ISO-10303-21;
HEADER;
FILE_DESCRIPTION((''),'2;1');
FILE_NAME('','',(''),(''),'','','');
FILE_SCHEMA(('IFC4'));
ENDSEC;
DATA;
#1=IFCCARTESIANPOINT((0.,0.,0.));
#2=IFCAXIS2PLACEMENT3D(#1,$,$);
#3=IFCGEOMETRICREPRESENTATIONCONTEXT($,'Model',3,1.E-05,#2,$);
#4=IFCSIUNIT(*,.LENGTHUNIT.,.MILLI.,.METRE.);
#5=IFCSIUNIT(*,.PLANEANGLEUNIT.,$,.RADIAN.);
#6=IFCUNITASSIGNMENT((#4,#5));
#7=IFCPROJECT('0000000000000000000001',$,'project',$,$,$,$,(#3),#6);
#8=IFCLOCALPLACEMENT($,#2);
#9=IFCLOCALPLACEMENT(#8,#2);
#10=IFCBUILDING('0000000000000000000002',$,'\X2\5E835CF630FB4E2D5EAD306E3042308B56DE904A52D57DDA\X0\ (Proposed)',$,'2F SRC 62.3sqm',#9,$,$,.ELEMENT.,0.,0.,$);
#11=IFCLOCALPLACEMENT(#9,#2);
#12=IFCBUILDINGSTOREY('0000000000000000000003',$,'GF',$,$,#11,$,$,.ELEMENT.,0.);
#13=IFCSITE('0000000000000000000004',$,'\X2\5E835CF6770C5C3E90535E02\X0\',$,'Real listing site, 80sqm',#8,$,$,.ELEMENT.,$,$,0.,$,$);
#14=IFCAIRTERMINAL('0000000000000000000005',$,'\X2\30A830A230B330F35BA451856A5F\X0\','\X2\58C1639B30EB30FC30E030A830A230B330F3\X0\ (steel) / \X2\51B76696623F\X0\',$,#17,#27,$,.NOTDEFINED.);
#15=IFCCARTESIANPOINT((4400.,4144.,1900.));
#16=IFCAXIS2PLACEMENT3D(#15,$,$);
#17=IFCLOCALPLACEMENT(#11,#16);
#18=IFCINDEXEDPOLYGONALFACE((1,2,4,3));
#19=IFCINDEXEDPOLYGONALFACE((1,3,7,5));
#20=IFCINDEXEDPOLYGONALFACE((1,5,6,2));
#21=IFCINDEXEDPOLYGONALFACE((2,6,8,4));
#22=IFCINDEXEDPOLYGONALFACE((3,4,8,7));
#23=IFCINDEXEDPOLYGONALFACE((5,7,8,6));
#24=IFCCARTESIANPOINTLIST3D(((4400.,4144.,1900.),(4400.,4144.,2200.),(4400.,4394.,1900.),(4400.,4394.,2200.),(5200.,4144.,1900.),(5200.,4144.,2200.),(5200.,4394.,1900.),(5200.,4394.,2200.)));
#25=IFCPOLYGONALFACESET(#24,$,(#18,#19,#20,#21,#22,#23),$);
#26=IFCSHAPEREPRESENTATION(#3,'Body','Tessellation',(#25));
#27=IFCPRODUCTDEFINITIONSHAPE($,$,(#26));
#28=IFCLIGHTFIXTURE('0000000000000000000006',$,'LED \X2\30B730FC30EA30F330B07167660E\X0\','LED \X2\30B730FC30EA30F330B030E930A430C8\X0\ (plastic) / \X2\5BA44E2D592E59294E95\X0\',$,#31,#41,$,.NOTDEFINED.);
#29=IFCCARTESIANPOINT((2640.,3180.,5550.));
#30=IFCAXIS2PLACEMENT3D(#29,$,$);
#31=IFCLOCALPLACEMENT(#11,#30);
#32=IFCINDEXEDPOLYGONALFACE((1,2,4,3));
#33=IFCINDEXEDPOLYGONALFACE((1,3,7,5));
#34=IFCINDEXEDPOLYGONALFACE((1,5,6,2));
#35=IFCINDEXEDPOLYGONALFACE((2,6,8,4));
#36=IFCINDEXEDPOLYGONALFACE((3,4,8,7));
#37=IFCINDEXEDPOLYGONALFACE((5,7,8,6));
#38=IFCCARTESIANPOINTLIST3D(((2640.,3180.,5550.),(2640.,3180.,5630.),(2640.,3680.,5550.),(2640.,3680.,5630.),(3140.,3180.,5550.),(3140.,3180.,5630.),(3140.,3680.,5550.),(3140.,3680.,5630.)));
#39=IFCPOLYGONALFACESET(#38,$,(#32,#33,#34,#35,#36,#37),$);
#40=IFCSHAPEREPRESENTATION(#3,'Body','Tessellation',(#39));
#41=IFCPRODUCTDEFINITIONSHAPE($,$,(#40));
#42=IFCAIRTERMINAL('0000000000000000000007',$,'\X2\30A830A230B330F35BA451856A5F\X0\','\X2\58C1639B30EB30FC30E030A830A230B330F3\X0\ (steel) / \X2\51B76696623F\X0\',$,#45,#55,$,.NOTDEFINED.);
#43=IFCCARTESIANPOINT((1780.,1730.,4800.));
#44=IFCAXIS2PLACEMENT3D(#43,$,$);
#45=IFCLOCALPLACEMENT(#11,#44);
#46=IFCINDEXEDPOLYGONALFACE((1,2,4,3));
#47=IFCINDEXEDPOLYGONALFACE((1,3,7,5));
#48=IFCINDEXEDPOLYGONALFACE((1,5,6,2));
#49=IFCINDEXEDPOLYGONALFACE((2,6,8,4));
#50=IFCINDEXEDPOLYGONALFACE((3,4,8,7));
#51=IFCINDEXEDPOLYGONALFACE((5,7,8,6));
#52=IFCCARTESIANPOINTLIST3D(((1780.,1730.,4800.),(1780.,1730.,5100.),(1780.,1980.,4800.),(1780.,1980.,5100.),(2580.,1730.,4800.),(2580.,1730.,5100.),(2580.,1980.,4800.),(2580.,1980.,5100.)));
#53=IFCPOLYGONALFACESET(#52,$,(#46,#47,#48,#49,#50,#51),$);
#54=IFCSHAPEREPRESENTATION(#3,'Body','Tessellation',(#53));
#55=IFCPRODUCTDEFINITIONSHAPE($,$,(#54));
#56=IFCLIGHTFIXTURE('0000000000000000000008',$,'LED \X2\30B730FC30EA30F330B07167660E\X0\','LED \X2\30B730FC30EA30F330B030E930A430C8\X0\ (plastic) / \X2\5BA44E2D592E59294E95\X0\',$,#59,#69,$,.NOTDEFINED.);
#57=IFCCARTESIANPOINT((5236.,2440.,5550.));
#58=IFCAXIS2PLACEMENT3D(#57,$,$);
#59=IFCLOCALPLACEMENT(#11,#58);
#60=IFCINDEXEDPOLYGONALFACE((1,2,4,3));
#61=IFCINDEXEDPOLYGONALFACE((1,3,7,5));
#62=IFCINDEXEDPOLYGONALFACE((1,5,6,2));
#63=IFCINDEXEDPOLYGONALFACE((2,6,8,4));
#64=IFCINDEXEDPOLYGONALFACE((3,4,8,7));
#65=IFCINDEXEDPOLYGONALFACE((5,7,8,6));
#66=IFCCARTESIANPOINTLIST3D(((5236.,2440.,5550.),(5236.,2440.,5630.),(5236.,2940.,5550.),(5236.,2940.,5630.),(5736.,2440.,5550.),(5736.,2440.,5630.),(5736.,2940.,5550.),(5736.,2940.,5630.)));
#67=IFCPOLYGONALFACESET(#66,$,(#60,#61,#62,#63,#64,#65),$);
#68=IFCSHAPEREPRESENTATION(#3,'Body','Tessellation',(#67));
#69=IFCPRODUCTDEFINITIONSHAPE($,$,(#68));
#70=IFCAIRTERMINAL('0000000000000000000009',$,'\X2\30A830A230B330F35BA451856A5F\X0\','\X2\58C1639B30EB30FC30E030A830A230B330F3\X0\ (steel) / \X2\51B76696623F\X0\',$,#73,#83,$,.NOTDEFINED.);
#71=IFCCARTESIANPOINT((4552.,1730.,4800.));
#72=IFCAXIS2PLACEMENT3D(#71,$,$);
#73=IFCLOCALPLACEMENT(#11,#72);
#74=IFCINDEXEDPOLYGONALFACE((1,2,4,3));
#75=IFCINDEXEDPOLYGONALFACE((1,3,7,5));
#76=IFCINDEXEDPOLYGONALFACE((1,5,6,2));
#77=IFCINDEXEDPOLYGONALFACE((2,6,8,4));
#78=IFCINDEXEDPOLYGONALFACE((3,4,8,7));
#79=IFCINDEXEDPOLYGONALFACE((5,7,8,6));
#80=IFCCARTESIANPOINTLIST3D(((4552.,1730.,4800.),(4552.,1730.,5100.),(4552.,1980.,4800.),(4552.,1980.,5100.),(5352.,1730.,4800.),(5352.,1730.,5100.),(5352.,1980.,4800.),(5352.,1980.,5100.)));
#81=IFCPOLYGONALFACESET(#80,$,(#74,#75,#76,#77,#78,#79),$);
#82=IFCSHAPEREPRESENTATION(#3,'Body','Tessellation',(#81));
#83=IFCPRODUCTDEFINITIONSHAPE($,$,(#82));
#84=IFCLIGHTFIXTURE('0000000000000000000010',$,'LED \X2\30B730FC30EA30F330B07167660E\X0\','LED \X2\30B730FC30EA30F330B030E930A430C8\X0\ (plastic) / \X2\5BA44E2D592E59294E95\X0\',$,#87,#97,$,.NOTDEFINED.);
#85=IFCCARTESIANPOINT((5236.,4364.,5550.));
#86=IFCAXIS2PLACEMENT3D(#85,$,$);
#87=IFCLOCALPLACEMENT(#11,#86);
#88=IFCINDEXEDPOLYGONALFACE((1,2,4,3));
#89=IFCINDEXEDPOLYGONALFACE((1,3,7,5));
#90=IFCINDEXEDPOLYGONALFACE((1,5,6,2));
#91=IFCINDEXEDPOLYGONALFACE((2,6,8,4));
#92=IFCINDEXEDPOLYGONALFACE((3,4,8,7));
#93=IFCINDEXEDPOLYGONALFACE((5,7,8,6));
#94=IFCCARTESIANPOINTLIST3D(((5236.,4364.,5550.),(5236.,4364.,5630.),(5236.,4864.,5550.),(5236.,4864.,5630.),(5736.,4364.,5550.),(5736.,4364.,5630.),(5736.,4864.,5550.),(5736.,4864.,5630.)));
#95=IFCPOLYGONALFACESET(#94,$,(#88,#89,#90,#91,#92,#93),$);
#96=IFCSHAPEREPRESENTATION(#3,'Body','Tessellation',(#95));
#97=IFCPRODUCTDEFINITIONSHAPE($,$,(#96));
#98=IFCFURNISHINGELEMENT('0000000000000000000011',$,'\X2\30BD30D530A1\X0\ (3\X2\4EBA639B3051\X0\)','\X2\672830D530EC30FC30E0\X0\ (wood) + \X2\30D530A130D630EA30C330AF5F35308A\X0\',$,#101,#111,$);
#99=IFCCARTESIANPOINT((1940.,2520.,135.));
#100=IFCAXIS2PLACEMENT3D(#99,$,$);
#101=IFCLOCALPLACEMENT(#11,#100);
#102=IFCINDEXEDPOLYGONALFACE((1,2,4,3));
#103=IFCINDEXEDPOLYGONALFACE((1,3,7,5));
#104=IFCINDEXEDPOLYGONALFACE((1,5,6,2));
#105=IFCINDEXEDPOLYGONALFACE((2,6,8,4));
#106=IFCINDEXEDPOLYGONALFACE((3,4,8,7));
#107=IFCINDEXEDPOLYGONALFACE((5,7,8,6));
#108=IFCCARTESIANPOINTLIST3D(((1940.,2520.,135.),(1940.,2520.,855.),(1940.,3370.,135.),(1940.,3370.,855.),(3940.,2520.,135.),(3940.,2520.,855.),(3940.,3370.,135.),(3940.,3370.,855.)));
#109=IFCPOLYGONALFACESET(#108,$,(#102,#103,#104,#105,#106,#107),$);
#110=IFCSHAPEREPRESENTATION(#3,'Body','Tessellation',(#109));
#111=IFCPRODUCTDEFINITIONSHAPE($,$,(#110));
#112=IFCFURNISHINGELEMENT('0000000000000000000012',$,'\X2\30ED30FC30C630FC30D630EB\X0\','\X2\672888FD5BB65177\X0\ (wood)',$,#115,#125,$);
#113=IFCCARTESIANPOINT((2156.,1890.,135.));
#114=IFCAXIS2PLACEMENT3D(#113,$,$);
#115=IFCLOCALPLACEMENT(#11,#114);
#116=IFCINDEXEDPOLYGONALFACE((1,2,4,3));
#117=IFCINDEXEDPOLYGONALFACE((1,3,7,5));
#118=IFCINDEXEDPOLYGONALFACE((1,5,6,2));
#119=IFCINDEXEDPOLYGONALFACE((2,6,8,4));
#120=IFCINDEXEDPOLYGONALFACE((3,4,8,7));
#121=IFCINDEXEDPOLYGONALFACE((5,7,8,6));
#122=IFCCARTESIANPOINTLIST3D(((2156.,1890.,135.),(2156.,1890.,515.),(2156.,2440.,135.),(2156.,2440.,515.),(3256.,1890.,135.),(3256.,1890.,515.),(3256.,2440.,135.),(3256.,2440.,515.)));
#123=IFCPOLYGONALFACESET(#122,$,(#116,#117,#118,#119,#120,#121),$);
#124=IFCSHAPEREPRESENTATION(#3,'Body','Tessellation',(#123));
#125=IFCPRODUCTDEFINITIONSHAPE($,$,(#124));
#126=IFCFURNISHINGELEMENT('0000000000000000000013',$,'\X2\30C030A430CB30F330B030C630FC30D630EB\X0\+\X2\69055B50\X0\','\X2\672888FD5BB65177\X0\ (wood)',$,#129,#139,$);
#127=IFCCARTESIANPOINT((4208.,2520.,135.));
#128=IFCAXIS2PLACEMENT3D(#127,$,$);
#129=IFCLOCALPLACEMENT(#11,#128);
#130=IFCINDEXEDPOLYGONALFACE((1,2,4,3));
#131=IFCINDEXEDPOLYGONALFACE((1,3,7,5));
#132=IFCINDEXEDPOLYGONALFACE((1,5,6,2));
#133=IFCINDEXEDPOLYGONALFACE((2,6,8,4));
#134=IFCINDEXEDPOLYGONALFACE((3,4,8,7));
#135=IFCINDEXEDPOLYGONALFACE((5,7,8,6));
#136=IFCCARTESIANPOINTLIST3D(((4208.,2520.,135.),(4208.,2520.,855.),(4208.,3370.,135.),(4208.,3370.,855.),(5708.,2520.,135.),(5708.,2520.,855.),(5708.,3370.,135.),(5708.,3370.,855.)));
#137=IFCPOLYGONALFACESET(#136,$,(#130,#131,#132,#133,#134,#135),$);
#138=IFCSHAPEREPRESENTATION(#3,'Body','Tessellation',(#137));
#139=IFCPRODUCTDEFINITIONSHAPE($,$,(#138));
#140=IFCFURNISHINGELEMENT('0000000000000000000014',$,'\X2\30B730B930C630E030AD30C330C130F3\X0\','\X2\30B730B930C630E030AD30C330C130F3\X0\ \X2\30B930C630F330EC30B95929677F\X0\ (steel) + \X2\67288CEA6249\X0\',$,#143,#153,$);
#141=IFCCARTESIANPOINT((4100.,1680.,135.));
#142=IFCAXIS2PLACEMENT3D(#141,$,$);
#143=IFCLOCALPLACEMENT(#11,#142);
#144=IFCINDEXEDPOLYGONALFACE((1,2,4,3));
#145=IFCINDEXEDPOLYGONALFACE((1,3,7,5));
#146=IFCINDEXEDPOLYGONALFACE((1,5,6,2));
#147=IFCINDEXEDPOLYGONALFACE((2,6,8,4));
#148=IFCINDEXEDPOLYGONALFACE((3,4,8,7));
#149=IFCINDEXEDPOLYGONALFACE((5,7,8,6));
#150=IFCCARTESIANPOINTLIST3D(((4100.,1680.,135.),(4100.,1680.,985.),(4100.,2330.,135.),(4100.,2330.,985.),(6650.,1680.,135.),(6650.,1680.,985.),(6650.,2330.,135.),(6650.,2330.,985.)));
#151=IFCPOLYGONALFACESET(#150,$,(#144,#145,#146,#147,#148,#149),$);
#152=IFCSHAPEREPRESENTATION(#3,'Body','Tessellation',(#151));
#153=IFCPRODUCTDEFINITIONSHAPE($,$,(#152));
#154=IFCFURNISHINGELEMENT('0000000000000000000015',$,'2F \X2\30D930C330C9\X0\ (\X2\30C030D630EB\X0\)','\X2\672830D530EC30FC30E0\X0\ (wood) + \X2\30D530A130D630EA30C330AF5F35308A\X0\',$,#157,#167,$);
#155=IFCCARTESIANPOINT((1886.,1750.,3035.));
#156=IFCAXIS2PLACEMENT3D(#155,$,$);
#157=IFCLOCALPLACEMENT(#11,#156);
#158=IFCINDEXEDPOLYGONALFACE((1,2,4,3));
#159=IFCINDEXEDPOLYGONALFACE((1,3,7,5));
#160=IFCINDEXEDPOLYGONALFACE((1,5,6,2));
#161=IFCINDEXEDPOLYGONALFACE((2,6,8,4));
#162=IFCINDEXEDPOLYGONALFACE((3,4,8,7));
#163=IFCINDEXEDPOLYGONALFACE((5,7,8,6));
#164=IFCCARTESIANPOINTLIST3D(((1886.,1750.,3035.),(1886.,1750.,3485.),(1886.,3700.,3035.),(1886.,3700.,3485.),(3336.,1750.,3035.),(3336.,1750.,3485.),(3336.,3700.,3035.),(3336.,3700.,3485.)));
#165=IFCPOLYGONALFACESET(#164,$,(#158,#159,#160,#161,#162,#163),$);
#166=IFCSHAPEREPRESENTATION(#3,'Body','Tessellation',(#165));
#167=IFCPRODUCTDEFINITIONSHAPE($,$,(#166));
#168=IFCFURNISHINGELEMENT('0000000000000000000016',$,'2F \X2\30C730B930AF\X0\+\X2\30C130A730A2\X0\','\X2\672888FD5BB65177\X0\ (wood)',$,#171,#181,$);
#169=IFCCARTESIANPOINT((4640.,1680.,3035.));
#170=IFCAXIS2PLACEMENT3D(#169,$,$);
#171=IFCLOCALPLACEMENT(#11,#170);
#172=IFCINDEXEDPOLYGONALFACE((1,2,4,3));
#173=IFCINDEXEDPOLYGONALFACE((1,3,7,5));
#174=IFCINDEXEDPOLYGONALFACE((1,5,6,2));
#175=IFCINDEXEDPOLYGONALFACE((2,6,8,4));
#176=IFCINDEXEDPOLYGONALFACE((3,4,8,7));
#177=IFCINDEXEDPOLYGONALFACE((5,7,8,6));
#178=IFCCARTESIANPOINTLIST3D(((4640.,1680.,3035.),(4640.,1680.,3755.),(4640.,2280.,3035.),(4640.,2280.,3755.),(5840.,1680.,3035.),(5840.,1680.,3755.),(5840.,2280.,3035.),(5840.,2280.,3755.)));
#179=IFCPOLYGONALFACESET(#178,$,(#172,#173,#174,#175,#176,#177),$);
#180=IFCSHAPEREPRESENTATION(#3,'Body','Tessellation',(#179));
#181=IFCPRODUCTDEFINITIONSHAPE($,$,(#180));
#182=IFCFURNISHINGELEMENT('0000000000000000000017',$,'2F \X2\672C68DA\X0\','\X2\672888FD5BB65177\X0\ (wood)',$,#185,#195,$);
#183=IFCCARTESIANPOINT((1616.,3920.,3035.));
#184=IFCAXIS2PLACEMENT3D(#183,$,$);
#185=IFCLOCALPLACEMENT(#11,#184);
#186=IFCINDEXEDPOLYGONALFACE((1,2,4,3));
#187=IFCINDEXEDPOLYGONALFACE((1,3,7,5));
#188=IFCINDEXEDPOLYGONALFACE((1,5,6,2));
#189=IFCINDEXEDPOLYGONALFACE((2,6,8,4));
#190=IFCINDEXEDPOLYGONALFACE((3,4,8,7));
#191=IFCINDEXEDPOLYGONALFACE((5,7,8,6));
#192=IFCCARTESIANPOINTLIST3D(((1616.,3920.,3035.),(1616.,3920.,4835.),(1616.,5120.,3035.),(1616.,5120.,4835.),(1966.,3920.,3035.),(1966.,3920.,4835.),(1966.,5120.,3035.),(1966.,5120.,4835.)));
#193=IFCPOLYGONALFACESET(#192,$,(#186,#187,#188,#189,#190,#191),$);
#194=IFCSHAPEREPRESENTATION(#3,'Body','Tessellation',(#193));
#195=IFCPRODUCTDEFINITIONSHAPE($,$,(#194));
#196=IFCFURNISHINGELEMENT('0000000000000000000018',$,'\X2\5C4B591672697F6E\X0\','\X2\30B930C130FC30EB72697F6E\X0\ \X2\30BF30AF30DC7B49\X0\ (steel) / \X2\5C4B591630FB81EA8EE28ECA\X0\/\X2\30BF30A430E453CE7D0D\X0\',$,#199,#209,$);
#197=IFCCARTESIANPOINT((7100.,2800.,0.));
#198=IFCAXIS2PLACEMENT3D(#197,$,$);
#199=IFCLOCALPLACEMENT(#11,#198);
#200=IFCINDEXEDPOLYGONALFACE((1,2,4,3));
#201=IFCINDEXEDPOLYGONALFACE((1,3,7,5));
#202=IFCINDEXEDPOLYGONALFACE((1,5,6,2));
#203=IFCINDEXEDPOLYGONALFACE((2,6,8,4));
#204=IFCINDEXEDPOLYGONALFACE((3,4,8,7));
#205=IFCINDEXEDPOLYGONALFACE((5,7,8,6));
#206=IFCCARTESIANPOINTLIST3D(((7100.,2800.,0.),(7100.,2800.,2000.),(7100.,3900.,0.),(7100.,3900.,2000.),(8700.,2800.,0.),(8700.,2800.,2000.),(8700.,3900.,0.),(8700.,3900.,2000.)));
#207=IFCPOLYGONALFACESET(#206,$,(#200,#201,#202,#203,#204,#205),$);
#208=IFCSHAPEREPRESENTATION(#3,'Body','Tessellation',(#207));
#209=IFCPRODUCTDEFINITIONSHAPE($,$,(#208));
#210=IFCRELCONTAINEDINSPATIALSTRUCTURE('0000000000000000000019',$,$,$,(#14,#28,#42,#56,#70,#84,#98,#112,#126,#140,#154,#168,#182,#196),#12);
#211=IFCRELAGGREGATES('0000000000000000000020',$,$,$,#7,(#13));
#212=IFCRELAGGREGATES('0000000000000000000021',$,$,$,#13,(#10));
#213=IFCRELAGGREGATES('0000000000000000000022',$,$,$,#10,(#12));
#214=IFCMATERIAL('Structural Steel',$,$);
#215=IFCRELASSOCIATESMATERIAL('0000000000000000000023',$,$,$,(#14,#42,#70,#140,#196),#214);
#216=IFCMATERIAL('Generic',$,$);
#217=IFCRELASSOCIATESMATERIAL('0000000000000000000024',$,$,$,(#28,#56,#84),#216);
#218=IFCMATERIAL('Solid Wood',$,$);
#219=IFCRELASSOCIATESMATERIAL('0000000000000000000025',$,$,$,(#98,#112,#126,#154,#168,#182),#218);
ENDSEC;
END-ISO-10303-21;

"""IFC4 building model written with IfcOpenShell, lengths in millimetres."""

from ifc_helpers import new_model, si_unit, frame, frame_2d, origin, place, context, project, spatial, rectangle, extrude, material, element, save


model = new_model("IFC4")

# Units and contexts
model_context = context("Model", 3, precision=1e-05, world=origin())
ifc_project = project(units=[si_unit("LENGTHUNIT", "METRE", prefix="MILLI"), si_unit("PLANEANGLEUNIT", "RADIAN")], contexts=[model_context])

# Site, building, storey
site_placement = place(None, origin())
site = spatial("IfcSite", under=ifc_project, at=site_placement, Name="広島県尾道市", ObjectType="Real listing site, 80sqm", CompositionType="ELEMENT", RefElevation=0.0)
building_placement = place(site_placement, origin())
building = spatial("IfcBuilding", under=site, at=building_placement, Name="広島・中庭のある回遊動線 (Proposed)", ObjectType="2F SRC 62.3sqm", CompositionType="ELEMENT", ElevationOfRefHeight=0.0, ElevationOfTerrain=0.0)
storey_placement = place(building_placement, origin())
storey = spatial("IfcBuildingStorey", under=building, at=storey_placement, Name="GF", CompositionType="ELEMENT", Elevation=0.0)

# Shared definitions
ifc_material_1 = material(Name="Solid Wood")

# Shared definitions
ifc_material_2 = material(Name="Structural Steel")

# Shared definitions
ifc_material_3 = material(Name="Generic")

# Air terminal
air_terminal_1_placement = place(storey_placement, frame((4400.0, 4144.0, 1900.0)))
element("IfcAirTerminal", 1, at=air_terminal_1_placement, inside=storey, material=ifc_material_2, Name="エアコン室内機", Description="壁掛ルームエアコン (steel) / 冷暖房", PredefinedType="NOTDEFINED", context=model_context, shape_type="SweptSolid", body=[
    extrude(rectangle(XDim=800.0, YDim=250.0, at=frame_2d((400.0, 125.0))), frame((4400.0, 4144.0, 1900.0)), (0.0, 0.0, 1.0), 300.0),
])

# Light fixture
light_fixture_1_placement = place(storey_placement, frame((2640.0, 3180.0, 5550.0)))
element("IfcLightFixture", 2, at=light_fixture_1_placement, inside=storey, material=ifc_material_3, Name="LED シーリング照明", Description="LED シーリングライト (plastic) / 室中央天井", PredefinedType="NOTDEFINED", context=model_context, shape_type="SweptSolid", body=[
    extrude(rectangle(XDim=500.0, YDim=500.0, at=frame_2d((250.0, 250.0))), frame((2640.0, 3180.0, 5550.0)), (0.0, 0.0, 1.0), 80.0),
])

# Air terminal
air_terminal_2_placement = place(storey_placement, frame((1780.0, 1730.0, 4800.0)))
element("IfcAirTerminal", 3, at=air_terminal_2_placement, inside=storey, material=ifc_material_2, Name="エアコン室内機", Description="壁掛ルームエアコン (steel) / 冷暖房", PredefinedType="NOTDEFINED", context=model_context, shape_type="SweptSolid", body=[
    extrude(rectangle(XDim=800.0, YDim=250.0, at=frame_2d((400.0, 125.0))), frame((1780.0, 1730.0, 4800.0)), (0.0, 0.0, 1.0), 300.0),
])

# Light fixture
light_fixture_2_placement = place(storey_placement, frame((5236.0, 2440.0, 5550.0)))
element("IfcLightFixture", 4, at=light_fixture_2_placement, inside=storey, material=ifc_material_3, Name="LED シーリング照明", Description="LED シーリングライト (plastic) / 室中央天井", PredefinedType="NOTDEFINED", context=model_context, shape_type="SweptSolid", body=[
    extrude(rectangle(XDim=500.0, YDim=500.0, at=frame_2d((250.0, 250.0))), frame((5236.0, 2440.0, 5550.0)), (0.0, 0.0, 1.0), 80.0),
])

# Air terminal
air_terminal_3_placement = place(storey_placement, frame((4552.0, 1730.0, 4800.0)))
element("IfcAirTerminal", 5, at=air_terminal_3_placement, inside=storey, material=ifc_material_2, Name="エアコン室内機", Description="壁掛ルームエアコン (steel) / 冷暖房", PredefinedType="NOTDEFINED", context=model_context, shape_type="SweptSolid", body=[
    extrude(rectangle(XDim=800.0, YDim=250.0, at=frame_2d((400.0, 125.0))), frame((4552.0, 1730.0, 4800.0)), (0.0, 0.0, 1.0), 300.0),
])

# Light fixture
light_fixture_3_placement = place(storey_placement, frame((5236.0, 4364.0, 5550.0)))
element("IfcLightFixture", 6, at=light_fixture_3_placement, inside=storey, material=ifc_material_3, Name="LED シーリング照明", Description="LED シーリングライト (plastic) / 室中央天井", PredefinedType="NOTDEFINED", context=model_context, shape_type="SweptSolid", body=[
    extrude(rectangle(XDim=500.0, YDim=500.0, at=frame_2d((250.0, 250.0))), frame((5236.0, 4364.0, 5550.0)), (0.0, 0.0, 1.0), 80.0),
])

# Furnishing elements
furnishing_1_placement = place(storey_placement, frame((1940.0, 2520.0, 135.0)))
element("IfcFurnishingElement", 7, at=furnishing_1_placement, inside=storey, material=ifc_material_1, Name="ソファ (3人掛け)", Description="木フレーム (wood) + ファブリック張り", context=model_context, shape_type="SweptSolid", body=[
    extrude(rectangle(XDim=2000.0, YDim=850.0, at=frame_2d((1000.0, 425.0))), frame((1940.0, 2520.0, 135.0)), (0.0, 0.0, 1.0), 720.0),
])
furnishing_2_placement = place(storey_placement, frame((2156.0, 1890.0, 135.0)))
element("IfcFurnishingElement", 8, at=furnishing_2_placement, inside=storey, material=ifc_material_1, Name="ローテーブル", Description="木製家具 (wood)", context=model_context, shape_type="SweptSolid", body=[
    extrude(rectangle(XDim=1100.0, YDim=550.0, at=frame_2d((550.0, 275.0))), frame((2156.0, 1890.0, 135.0)), (0.0, 0.0, 1.0), 380.0),
])
furnishing_3_placement = place(storey_placement, frame((4208.0, 2520.0, 135.0)))
element("IfcFurnishingElement", 9, at=furnishing_3_placement, inside=storey, material=ifc_material_1, Name="ダイニングテーブル+椅子", Description="木製家具 (wood)", context=model_context, shape_type="SweptSolid", body=[
    extrude(rectangle(XDim=1500.0, YDim=850.0, at=frame_2d((750.0, 425.0))), frame((4208.0, 2520.0, 135.0)), (0.0, 0.0, 1.0), 720.0),
])
furnishing_4_placement = place(storey_placement, frame((4100.0, 1680.0, 135.0)))
element("IfcFurnishingElement", 10, at=furnishing_4_placement, inside=storey, material=ifc_material_2, Name="システムキッチン", Description="システムキッチン ステンレス天板 (steel) + 木質扉", context=model_context, shape_type="SweptSolid", body=[
    extrude(rectangle(XDim=2550.0, YDim=650.0, at=frame_2d((1275.0, 325.0))), frame((4100.0, 1680.0, 135.0)), (0.0, 0.0, 1.0), 850.0),
])
furnishing_5_placement = place(storey_placement, frame((1886.0, 1750.0, 3035.0)))
element("IfcFurnishingElement", 11, at=furnishing_5_placement, inside=storey, material=ifc_material_1, Name="2F ベッド (ダブル)", Description="木フレーム (wood) + ファブリック張り", context=model_context, shape_type="SweptSolid", body=[
    extrude(rectangle(XDim=1450.0, YDim=1950.0, at=frame_2d((725.0, 975.0))), frame((1886.0, 1750.0, 3035.0)), (0.0, 0.0, 1.0), 450.0),
])
furnishing_6_placement = place(storey_placement, frame((4640.0, 1680.0, 3035.0)))
element("IfcFurnishingElement", 12, at=furnishing_6_placement, inside=storey, material=ifc_material_1, Name="2F デスク+チェア", Description="木製家具 (wood)", context=model_context, shape_type="SweptSolid", body=[
    extrude(rectangle(XDim=1200.0, YDim=600.0, at=frame_2d((600.0, 300.0))), frame((4640.0, 1680.0, 3035.0)), (0.0, 0.0, 1.0), 720.0),
])
furnishing_7_placement = place(storey_placement, frame((1616.0, 3920.0, 3035.0)))
element("IfcFurnishingElement", 13, at=furnishing_7_placement, inside=storey, material=ifc_material_1, Name="2F 本棚", Description="木製家具 (wood)", context=model_context, shape_type="SweptSolid", body=[
    extrude(rectangle(XDim=350.0, YDim=1200.0, at=frame_2d((175.0, 600.0))), frame((1616.0, 3920.0, 3035.0)), (0.0, 0.0, 1.0), 1800.0),
])
furnishing_8_placement = place(storey_placement, frame((7100.0, 2800.0, 0.0)))
element("IfcFurnishingElement", 14, at=furnishing_8_placement, inside=storey, material=ifc_material_2, Name="屋外物置", Description="スチール物置 タクボ等 (steel) / 屋外・自転車/タイヤ収納", context=model_context, shape_type="SweptSolid", body=[
    extrude(rectangle(XDim=1600.0, YDim=1100.0, at=frame_2d((800.0, 550.0))), frame((7100.0, 2800.0, 0.0)), (0.0, 0.0, 1.0), 2000.0),
])

save(model, "model.ifc")
